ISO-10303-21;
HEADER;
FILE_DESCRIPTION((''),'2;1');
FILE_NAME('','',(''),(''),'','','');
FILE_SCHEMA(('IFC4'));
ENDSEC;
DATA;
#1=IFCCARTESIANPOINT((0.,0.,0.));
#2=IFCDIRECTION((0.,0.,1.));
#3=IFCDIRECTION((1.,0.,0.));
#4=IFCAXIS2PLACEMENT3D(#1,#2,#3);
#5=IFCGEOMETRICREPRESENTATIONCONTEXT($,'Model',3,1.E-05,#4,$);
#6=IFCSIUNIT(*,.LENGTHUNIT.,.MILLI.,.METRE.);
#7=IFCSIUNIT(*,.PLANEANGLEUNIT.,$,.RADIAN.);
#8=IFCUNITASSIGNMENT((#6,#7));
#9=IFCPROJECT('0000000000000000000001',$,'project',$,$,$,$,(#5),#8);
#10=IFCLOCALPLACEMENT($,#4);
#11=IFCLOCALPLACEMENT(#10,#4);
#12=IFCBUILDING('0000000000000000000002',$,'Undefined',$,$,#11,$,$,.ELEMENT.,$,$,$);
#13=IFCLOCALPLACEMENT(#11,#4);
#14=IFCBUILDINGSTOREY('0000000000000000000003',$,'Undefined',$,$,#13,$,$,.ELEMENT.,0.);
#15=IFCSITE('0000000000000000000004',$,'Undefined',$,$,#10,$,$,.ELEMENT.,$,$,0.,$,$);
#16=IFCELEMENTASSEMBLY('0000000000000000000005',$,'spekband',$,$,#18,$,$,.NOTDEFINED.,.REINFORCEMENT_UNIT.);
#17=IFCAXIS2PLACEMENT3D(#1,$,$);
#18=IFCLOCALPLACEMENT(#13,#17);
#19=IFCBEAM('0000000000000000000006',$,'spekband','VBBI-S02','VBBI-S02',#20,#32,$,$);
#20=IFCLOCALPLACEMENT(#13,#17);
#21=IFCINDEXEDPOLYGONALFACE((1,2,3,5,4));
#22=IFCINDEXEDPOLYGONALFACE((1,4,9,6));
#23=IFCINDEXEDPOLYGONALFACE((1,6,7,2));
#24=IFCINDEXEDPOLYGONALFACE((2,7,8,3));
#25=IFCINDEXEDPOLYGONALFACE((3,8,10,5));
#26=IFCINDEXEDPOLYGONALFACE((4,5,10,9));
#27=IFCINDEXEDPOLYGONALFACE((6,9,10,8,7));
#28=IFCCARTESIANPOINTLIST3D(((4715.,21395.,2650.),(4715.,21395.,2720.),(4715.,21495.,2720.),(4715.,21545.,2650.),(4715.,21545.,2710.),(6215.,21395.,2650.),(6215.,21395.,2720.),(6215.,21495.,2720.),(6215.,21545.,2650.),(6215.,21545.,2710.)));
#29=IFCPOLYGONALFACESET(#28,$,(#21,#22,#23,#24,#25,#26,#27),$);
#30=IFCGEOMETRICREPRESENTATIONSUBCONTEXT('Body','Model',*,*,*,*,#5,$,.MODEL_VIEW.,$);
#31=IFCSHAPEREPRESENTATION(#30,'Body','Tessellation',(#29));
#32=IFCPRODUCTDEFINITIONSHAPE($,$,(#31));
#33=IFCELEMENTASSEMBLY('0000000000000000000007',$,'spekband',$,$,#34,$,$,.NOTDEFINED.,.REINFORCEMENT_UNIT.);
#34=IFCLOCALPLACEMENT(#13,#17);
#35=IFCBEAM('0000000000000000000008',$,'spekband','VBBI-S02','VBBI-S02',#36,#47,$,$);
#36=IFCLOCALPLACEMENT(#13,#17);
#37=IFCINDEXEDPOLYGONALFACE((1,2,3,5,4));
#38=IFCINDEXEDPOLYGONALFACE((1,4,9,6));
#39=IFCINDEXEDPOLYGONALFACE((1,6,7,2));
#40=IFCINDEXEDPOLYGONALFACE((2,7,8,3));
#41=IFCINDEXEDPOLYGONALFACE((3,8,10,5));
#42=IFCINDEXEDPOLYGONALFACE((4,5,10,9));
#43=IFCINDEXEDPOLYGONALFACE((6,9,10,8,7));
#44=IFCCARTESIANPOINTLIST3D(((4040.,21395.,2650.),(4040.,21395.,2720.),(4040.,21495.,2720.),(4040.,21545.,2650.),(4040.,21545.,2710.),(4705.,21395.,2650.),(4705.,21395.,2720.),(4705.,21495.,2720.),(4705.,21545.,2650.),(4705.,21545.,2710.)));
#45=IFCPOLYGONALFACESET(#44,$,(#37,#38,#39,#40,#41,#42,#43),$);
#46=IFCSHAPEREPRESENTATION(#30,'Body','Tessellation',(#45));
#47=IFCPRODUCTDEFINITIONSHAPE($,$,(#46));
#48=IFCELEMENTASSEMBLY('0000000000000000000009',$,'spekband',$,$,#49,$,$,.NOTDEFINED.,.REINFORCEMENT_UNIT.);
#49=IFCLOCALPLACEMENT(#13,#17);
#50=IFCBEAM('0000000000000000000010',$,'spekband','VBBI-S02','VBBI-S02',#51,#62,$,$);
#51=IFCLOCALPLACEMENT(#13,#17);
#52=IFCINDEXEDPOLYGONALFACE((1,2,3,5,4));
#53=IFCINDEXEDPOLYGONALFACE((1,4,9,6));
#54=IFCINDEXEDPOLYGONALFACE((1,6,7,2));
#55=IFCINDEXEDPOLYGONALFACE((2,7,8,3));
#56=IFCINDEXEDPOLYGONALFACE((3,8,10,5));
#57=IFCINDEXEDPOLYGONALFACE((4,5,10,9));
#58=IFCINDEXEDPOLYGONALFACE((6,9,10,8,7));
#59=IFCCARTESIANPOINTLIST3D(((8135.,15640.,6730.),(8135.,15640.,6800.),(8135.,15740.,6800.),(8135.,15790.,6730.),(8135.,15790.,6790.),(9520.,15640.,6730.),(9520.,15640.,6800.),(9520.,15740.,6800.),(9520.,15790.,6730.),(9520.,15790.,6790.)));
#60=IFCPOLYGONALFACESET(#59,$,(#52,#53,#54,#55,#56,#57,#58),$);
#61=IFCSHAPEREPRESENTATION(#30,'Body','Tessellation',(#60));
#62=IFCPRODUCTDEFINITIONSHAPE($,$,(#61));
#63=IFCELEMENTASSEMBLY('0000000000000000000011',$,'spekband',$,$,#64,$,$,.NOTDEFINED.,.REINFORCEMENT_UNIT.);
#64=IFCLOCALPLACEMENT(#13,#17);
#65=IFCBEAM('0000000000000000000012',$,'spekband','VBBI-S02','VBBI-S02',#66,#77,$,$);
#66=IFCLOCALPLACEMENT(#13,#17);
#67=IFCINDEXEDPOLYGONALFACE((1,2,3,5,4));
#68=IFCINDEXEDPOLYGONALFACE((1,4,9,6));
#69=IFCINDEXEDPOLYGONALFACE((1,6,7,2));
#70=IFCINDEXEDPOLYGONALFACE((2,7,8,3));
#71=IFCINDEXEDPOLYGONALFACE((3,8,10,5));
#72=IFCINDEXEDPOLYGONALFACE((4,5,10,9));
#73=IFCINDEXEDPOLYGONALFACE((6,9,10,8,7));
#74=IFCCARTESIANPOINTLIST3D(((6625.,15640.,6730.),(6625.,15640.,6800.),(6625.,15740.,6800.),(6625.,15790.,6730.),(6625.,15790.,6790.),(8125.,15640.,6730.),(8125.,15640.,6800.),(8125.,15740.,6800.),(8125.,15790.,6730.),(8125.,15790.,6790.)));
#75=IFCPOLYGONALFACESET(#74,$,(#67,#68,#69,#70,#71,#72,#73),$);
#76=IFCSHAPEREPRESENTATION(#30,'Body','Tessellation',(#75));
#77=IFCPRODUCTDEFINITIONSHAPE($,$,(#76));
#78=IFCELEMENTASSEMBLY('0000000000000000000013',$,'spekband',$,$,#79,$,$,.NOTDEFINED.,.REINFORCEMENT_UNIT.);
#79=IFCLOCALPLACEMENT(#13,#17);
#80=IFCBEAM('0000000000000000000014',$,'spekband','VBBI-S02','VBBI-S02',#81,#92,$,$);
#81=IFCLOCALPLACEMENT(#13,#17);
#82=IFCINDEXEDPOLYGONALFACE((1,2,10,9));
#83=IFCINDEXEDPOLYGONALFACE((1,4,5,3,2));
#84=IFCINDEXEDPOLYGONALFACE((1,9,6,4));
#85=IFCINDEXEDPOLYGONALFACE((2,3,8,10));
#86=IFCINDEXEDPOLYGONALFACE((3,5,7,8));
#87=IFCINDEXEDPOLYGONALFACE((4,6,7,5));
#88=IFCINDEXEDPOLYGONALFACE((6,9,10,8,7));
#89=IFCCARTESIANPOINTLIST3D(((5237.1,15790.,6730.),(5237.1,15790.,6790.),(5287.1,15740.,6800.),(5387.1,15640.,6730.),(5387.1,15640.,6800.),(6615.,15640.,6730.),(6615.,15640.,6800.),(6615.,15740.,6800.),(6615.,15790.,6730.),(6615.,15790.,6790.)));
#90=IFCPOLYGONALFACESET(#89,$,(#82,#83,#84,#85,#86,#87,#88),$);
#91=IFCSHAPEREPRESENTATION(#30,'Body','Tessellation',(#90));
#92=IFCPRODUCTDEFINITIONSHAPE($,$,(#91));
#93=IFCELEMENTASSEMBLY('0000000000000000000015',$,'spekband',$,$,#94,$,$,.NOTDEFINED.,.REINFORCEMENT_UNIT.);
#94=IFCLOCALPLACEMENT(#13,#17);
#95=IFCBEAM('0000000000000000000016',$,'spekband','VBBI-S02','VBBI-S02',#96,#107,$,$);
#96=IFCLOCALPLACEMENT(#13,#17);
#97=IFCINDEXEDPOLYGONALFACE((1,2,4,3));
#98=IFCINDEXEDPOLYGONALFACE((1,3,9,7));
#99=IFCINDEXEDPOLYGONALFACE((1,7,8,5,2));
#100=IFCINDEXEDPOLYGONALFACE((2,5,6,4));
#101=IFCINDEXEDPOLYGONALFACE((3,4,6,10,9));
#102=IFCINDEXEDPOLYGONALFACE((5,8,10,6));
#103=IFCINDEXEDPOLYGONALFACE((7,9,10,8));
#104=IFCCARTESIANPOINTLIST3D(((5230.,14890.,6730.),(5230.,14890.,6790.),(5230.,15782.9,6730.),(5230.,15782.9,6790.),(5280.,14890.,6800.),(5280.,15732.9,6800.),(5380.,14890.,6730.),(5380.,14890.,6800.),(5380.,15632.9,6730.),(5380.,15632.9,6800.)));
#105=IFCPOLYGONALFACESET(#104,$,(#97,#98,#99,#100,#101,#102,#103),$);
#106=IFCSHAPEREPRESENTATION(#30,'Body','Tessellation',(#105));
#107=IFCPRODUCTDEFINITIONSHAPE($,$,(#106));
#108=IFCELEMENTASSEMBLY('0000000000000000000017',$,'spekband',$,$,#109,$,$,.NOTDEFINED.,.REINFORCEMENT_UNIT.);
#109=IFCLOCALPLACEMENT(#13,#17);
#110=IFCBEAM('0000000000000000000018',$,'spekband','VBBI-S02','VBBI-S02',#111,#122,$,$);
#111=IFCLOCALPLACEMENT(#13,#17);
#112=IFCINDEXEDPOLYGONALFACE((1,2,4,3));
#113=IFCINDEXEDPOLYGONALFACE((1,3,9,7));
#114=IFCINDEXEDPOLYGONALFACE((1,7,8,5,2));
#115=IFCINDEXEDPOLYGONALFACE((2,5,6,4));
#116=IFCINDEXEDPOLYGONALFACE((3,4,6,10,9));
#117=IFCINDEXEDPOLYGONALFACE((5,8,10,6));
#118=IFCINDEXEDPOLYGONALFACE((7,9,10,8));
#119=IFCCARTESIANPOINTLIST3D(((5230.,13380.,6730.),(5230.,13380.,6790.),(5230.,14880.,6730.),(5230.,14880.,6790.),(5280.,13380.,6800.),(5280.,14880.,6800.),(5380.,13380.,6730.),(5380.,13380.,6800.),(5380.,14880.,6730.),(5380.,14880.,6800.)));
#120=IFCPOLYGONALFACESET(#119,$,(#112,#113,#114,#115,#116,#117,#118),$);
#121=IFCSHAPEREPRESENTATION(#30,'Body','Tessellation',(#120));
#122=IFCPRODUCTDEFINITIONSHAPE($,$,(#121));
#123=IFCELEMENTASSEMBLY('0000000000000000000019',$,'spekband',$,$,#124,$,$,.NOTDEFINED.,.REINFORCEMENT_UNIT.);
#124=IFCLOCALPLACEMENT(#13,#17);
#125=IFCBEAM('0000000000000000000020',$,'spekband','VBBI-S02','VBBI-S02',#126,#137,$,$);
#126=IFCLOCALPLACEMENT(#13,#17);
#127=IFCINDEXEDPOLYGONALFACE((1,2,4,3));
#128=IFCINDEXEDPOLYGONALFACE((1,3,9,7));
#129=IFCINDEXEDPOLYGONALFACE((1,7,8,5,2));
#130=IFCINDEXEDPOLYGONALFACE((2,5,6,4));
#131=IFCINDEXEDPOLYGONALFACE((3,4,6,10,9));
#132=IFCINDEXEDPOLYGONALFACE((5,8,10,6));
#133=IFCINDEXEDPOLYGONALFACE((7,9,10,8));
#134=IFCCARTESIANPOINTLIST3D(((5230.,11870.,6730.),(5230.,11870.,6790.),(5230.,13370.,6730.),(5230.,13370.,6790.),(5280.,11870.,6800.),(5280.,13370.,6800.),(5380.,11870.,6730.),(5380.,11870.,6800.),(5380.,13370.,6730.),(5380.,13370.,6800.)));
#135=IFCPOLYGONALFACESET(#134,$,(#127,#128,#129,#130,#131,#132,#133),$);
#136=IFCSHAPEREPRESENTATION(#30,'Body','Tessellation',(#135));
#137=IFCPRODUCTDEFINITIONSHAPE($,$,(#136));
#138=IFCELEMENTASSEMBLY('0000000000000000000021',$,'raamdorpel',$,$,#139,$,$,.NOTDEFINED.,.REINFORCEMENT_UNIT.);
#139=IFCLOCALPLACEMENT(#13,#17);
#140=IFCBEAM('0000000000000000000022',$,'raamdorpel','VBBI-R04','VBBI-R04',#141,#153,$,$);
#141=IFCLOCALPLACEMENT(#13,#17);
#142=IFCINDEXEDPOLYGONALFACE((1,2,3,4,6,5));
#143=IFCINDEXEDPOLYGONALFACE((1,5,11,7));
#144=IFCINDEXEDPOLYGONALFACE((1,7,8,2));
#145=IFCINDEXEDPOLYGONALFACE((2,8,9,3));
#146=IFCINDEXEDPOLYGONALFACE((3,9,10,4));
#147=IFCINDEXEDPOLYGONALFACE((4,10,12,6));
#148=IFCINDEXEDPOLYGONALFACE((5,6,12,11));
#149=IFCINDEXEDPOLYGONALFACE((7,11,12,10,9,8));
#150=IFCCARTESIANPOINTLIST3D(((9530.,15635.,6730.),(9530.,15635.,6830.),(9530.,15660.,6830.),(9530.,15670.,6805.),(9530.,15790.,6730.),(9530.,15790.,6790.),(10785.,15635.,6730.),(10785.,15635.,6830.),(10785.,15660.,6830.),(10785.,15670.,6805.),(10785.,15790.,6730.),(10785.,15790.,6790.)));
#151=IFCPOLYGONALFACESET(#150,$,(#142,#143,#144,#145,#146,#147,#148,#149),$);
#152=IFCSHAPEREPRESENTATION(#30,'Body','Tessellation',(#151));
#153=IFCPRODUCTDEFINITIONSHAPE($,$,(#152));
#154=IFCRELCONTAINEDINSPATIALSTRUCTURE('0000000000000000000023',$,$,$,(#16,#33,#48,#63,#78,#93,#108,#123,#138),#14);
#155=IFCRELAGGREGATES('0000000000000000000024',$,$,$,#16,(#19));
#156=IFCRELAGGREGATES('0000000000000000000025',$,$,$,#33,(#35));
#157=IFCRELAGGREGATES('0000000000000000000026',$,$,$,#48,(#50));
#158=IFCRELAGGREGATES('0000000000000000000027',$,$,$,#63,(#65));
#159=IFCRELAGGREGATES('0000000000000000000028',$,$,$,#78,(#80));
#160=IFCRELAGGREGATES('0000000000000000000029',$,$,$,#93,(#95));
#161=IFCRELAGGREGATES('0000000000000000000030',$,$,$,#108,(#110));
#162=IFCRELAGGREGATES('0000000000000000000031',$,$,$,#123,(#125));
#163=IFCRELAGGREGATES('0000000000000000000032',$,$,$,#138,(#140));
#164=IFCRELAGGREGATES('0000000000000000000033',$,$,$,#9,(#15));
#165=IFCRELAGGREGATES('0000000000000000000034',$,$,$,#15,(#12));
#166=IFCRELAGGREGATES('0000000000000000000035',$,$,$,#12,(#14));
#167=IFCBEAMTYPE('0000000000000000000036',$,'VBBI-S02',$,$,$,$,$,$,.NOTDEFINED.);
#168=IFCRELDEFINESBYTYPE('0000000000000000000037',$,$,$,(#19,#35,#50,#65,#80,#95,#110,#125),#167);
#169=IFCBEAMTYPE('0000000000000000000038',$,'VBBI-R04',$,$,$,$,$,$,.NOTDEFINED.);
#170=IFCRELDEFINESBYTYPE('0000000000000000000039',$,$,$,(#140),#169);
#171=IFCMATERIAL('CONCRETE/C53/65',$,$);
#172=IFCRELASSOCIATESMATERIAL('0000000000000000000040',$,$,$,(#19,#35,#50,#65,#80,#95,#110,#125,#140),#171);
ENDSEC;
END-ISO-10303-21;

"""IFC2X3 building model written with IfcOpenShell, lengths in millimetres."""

from ifc_helpers import new_model, si_unit, frame, origin_with_axes, place, context, subcontext, project, spatial, polyline, outline, extrude, clip, halfspace, material, type_object, element, aggregate, save


model = new_model("IFC2X3")

# Units and contexts
model_context = context("Model", 3, precision=1e-05, world=origin_with_axes())
body_context = subcontext(model_context, "Body", "Model", "MODEL_VIEW")
ifc_project = project(units=[si_unit("LENGTHUNIT", "METRE", prefix="MILLI"), si_unit("PLANEANGLEUNIT", "RADIAN")], contexts=[model_context])

# Site, building, storey
site_placement = place(None, origin_with_axes())
site = spatial("IfcSite", under=ifc_project, at=site_placement, Name="Undefined", CompositionType="ELEMENT", RefElevation=0.0)
building_placement = place(site_placement, origin_with_axes())
building = spatial("IfcBuilding", under=site, at=building_placement, Name="Undefined", CompositionType="ELEMENT")
storey_placement = place(building_placement, origin_with_axes())
storey = spatial("IfcBuildingStorey", under=building, at=storey_placement, Name="Undefined", CompositionType="ELEMENT", Elevation=0.0)

# Element assemblies, beams
ifc_material = material(Name="CONCRETE/C53/65")
beam_type_1 = type_object("IfcBeamType", Name="VBBI-S02", PredefinedType="NOTDEFINED")
assembly_1_placement = place(storey_placement, origin_with_axes())
assembly_1 = element("IfcElementAssembly", 1, at=assembly_1_placement, inside=storey, Name="spekband", AssemblyPlace="NOTDEFINED", PredefinedType="REINFORCEMENT_UNIT")
beam_1_placement = place(assembly_1_placement, frame((6215.0, 21470.0, 2685.0), z_axis=(0.0, 1.0, 0.0), x_axis=(-1.0, 0.0, 0.0)))
beam_1 = element("IfcBeam", 2, at=beam_1_placement, type_object=beam_type_1, material=ifc_material, Name="spekband", Description="VBBI-S02", ObjectType="VBBI-S02", context=body_context, shape_type="SweptSolid", body=[
    extrude(outline(polyline([(35.0, -75.0), (-35.0, -75.0), (-35.0, 25.0), (-25.0, 75.0), (35.0, 75.0), (35.0, -75.0)])), frame((1500.0, 0.0, 0.0), z_axis=(-1.0, 0.0, 0.0), x_axis=(0.0, -1.0, 0.0)), (0.0, 0.0, 1.0), 1500.0),
])
aggregate(assembly_1, [beam_1])
assembly_2_placement = place(storey_placement, origin_with_axes())
assembly_2 = element("IfcElementAssembly", 3, at=assembly_2_placement, inside=storey, Name="spekband", AssemblyPlace="NOTDEFINED", PredefinedType="REINFORCEMENT_UNIT")
beam_2_placement = place(assembly_2_placement, frame((4705.0, 21470.0, 2685.0), z_axis=(0.0, 1.0, 0.0), x_axis=(-1.0, 0.0, 0.0)))
beam_2 = element("IfcBeam", 4, at=beam_2_placement, type_object=beam_type_1, material=ifc_material, Name="spekband", Description="VBBI-S02", ObjectType="VBBI-S02", context=body_context, shape_type="SweptSolid", body=[
    extrude(outline(polyline([(35.0, -75.0), (-35.0, -75.0), (-35.0, 25.0), (-25.0, 75.0), (35.0, 75.0), (35.0, -75.0)])), frame((665.0, 0.0, 0.0), z_axis=(-1.0, 0.0, 0.0), x_axis=(0.0, -1.0, 0.0)), (0.0, 0.0, 1.0), 665.0),
])
aggregate(assembly_2, [beam_2])
assembly_3_placement = place(storey_placement, origin_with_axes())
assembly_3 = element("IfcElementAssembly", 5, at=assembly_3_placement, inside=storey, Name="spekband", AssemblyPlace="NOTDEFINED", PredefinedType="REINFORCEMENT_UNIT")
beam_3_placement = place(assembly_3_placement, frame((9520.0, 15715.0, 6765.0), z_axis=(0.0, 1.0, 0.0), x_axis=(-1.0, 0.0, 0.0)))
beam_3 = element("IfcBeam", 6, at=beam_3_placement, type_object=beam_type_1, material=ifc_material, Name="spekband", Description="VBBI-S02", ObjectType="VBBI-S02", context=body_context, shape_type="SweptSolid", body=[
    extrude(outline(polyline([(35.0, -75.0), (-35.0, -75.0), (-35.0, 25.0), (-25.0, 75.0), (35.0, 75.0), (35.0, -75.0)])), frame((1385.0, 0.0, 0.0), z_axis=(-1.0, 0.0, 0.0), x_axis=(0.0, -1.0, 0.0)), (0.0, 0.0, 1.0), 1385.0),
])
aggregate(assembly_3, [beam_3])
assembly_4_placement = place(storey_placement, origin_with_axes())
assembly_4 = element("IfcElementAssembly", 7, at=assembly_4_placement, inside=storey, Name="spekband", AssemblyPlace="NOTDEFINED", PredefinedType="REINFORCEMENT_UNIT")
beam_4_placement = place(assembly_4_placement, frame((8125.0, 15715.0, 6765.0), z_axis=(0.0, 1.0, 0.0), x_axis=(-1.0, 0.0, 0.0)))
beam_4 = element("IfcBeam", 8, at=beam_4_placement, type_object=beam_type_1, material=ifc_material, Name="spekband", Description="VBBI-S02", ObjectType="VBBI-S02", context=body_context, shape_type="SweptSolid", body=[
    extrude(outline(polyline([(35.0, -75.0), (-35.0, -75.0), (-35.0, 25.0), (-25.0, 75.0), (35.0, 75.0), (35.0, -75.0)])), frame((1500.0, 0.0, 0.0), z_axis=(-1.0, 0.0, 0.0), x_axis=(0.0, -1.0, 0.0)), (0.0, 0.0, 1.0), 1500.0),
])
aggregate(assembly_4, [beam_4])
assembly_5_placement = place(storey_placement, origin_with_axes())
assembly_5 = element("IfcElementAssembly", 9, at=assembly_5_placement, inside=storey, Name="spekband", AssemblyPlace="NOTDEFINED", PredefinedType="REINFORCEMENT_UNIT")
beam_5_placement = place(assembly_5_placement, frame((6615.0, 15715.0, 6765.0), z_axis=(0.0, 1.0, 0.0), x_axis=(-1.0, 0.0, 0.0)))
beam_5 = element("IfcBeam", 10, at=beam_5_placement, type_object=beam_type_1, material=ifc_material, Name="spekband", Description="VBBI-S02", ObjectType="VBBI-S02", context=body_context, shape_type="Clipping", body=[
    clip(extrude(outline(polyline([(35.0, -75.0), (-35.0, -75.0), (-35.0, 25.0), (-25.0, 75.0), (35.0, 75.0), (35.0, -75.0)])), frame((1378.7, 0.0, 0.0), z_axis=(-1.0, 0.0, 0.0), x_axis=(0.0, -1.0, 0.0)), (0.0, 0.0, 1.0), 1378.7), halfspace(frame((1381.5, 0.0, 78.5), z_axis=(0.707106, 0.0, -0.707107), x_axis=(0.0, 1.0, 0.0)), False)),
])
aggregate(assembly_5, [beam_5])
assembly_6_placement = place(storey_placement, origin_with_axes())
assembly_6 = element("IfcElementAssembly", 11, at=assembly_6_placement, inside=storey, Name="spekband", AssemblyPlace="NOTDEFINED", PredefinedType="REINFORCEMENT_UNIT")
beam_6_placement = place(assembly_6_placement, frame((5305.0, 15790.0, 6765.0), z_axis=(-1.0, 0.0, 0.0), x_axis=(0.0, -1.0, 0.0)))
beam_6 = element("IfcBeam", 12, at=beam_6_placement, type_object=beam_type_1, material=ifc_material, Name="spekband", Description="VBBI-S02", ObjectType="VBBI-S02", context=body_context, shape_type="Clipping", body=[
    clip(extrude(outline(polyline([(35.0, -75.0), (-35.0, -75.0), (-35.0, 25.0), (-25.0, 75.0), (35.0, 75.0), (35.0, -75.0)])), frame((900.0, 0.0, 0.0), z_axis=(-1.0, 0.0, 0.0), x_axis=(0.0, -1.0, 0.0)), (0.0, 0.0, 1.0), 893.7), halfspace(frame((3.5, 0.0, 78.5), z_axis=(0.707107, 0.0, 0.707107), x_axis=(0.0, 1.0, 0.0)), True)),
])
aggregate(assembly_6, [beam_6])
assembly_7_placement = place(storey_placement, origin_with_axes())
assembly_7 = element("IfcElementAssembly", 13, at=assembly_7_placement, inside=storey, Name="spekband", AssemblyPlace="NOTDEFINED", PredefinedType="REINFORCEMENT_UNIT")
beam_7_placement = place(assembly_7_placement, frame((5305.0, 14880.0, 6765.0), z_axis=(-1.0, 0.0, 0.0), x_axis=(0.0, -1.0, 0.0)))
beam_7 = element("IfcBeam", 14, at=beam_7_placement, type_object=beam_type_1, material=ifc_material, Name="spekband", Description="VBBI-S02", ObjectType="VBBI-S02", context=body_context, shape_type="SweptSolid", body=[
    extrude(outline(polyline([(35.0, -75.0), (-35.0, -75.0), (-35.0, 25.0), (-25.0, 75.0), (35.0, 75.0), (35.0, -75.0)])), frame((1500.0, 0.0, 0.0), z_axis=(-1.0, 0.0, 0.0), x_axis=(0.0, -1.0, 0.0)), (0.0, 0.0, 1.0), 1500.0),
])
aggregate(assembly_7, [beam_7])
assembly_8_placement = place(storey_placement, origin_with_axes())
assembly_8 = element("IfcElementAssembly", 15, at=assembly_8_placement, inside=storey, Name="spekband", AssemblyPlace="NOTDEFINED", PredefinedType="REINFORCEMENT_UNIT")
beam_8_placement = place(assembly_8_placement, frame((5305.0, 13370.0, 6765.0), z_axis=(-1.0, 0.0, 0.0), x_axis=(0.0, -1.0, 0.0)))
beam_8 = element("IfcBeam", 16, at=beam_8_placement, type_object=beam_type_1, material=ifc_material, Name="spekband", Description="VBBI-S02", ObjectType="VBBI-S02", context=body_context, shape_type="SweptSolid", body=[
    extrude(outline(polyline([(35.0, -75.0), (-35.0, -75.0), (-35.0, 25.0), (-25.0, 75.0), (35.0, 75.0), (35.0, -75.0)])), frame((1500.0, 0.0, 0.0), z_axis=(-1.0, 0.0, 0.0), x_axis=(0.0, -1.0, 0.0)), (0.0, 0.0, 1.0), 1500.0),
])
aggregate(assembly_8, [beam_8])
assembly_9_placement = place(storey_placement, origin_with_axes())
assembly_9 = element("IfcElementAssembly", 17, at=assembly_9_placement, inside=storey, Name="raamdorpel", AssemblyPlace="NOTDEFINED", PredefinedType="REINFORCEMENT_UNIT")
beam_type_2 = type_object("IfcBeamType", Name="VBBI-R04", PredefinedType="NOTDEFINED")
beam_9_placement = place(assembly_9_placement, frame((10785.0, 15712.5, 6780.0), z_axis=(0.0, 1.0, 0.0), x_axis=(-1.0, 0.0, 0.0)))
beam_9 = element("IfcBeam", 18, at=beam_9_placement, type_object=beam_type_2, material=ifc_material, Name="raamdorpel", Description="VBBI-R04", ObjectType="VBBI-R04", context=body_context, shape_type="SweptSolid", body=[
    extrude(outline(polyline([(50.0, -77.5), (-50.0, -77.5), (-50.0, -52.5), (-25.0, -42.5), (-10.0, 77.5), (50.0, 77.5), (50.0, -77.5)])), frame((1255.0, 0.0, 0.0), z_axis=(-1.0, 0.0, 0.0), x_axis=(0.0, -1.0, 0.0)), (0.0, 0.0, 1.0), 1255.0),
])
aggregate(assembly_9, [beam_9])

save(model, "model.ifc")
